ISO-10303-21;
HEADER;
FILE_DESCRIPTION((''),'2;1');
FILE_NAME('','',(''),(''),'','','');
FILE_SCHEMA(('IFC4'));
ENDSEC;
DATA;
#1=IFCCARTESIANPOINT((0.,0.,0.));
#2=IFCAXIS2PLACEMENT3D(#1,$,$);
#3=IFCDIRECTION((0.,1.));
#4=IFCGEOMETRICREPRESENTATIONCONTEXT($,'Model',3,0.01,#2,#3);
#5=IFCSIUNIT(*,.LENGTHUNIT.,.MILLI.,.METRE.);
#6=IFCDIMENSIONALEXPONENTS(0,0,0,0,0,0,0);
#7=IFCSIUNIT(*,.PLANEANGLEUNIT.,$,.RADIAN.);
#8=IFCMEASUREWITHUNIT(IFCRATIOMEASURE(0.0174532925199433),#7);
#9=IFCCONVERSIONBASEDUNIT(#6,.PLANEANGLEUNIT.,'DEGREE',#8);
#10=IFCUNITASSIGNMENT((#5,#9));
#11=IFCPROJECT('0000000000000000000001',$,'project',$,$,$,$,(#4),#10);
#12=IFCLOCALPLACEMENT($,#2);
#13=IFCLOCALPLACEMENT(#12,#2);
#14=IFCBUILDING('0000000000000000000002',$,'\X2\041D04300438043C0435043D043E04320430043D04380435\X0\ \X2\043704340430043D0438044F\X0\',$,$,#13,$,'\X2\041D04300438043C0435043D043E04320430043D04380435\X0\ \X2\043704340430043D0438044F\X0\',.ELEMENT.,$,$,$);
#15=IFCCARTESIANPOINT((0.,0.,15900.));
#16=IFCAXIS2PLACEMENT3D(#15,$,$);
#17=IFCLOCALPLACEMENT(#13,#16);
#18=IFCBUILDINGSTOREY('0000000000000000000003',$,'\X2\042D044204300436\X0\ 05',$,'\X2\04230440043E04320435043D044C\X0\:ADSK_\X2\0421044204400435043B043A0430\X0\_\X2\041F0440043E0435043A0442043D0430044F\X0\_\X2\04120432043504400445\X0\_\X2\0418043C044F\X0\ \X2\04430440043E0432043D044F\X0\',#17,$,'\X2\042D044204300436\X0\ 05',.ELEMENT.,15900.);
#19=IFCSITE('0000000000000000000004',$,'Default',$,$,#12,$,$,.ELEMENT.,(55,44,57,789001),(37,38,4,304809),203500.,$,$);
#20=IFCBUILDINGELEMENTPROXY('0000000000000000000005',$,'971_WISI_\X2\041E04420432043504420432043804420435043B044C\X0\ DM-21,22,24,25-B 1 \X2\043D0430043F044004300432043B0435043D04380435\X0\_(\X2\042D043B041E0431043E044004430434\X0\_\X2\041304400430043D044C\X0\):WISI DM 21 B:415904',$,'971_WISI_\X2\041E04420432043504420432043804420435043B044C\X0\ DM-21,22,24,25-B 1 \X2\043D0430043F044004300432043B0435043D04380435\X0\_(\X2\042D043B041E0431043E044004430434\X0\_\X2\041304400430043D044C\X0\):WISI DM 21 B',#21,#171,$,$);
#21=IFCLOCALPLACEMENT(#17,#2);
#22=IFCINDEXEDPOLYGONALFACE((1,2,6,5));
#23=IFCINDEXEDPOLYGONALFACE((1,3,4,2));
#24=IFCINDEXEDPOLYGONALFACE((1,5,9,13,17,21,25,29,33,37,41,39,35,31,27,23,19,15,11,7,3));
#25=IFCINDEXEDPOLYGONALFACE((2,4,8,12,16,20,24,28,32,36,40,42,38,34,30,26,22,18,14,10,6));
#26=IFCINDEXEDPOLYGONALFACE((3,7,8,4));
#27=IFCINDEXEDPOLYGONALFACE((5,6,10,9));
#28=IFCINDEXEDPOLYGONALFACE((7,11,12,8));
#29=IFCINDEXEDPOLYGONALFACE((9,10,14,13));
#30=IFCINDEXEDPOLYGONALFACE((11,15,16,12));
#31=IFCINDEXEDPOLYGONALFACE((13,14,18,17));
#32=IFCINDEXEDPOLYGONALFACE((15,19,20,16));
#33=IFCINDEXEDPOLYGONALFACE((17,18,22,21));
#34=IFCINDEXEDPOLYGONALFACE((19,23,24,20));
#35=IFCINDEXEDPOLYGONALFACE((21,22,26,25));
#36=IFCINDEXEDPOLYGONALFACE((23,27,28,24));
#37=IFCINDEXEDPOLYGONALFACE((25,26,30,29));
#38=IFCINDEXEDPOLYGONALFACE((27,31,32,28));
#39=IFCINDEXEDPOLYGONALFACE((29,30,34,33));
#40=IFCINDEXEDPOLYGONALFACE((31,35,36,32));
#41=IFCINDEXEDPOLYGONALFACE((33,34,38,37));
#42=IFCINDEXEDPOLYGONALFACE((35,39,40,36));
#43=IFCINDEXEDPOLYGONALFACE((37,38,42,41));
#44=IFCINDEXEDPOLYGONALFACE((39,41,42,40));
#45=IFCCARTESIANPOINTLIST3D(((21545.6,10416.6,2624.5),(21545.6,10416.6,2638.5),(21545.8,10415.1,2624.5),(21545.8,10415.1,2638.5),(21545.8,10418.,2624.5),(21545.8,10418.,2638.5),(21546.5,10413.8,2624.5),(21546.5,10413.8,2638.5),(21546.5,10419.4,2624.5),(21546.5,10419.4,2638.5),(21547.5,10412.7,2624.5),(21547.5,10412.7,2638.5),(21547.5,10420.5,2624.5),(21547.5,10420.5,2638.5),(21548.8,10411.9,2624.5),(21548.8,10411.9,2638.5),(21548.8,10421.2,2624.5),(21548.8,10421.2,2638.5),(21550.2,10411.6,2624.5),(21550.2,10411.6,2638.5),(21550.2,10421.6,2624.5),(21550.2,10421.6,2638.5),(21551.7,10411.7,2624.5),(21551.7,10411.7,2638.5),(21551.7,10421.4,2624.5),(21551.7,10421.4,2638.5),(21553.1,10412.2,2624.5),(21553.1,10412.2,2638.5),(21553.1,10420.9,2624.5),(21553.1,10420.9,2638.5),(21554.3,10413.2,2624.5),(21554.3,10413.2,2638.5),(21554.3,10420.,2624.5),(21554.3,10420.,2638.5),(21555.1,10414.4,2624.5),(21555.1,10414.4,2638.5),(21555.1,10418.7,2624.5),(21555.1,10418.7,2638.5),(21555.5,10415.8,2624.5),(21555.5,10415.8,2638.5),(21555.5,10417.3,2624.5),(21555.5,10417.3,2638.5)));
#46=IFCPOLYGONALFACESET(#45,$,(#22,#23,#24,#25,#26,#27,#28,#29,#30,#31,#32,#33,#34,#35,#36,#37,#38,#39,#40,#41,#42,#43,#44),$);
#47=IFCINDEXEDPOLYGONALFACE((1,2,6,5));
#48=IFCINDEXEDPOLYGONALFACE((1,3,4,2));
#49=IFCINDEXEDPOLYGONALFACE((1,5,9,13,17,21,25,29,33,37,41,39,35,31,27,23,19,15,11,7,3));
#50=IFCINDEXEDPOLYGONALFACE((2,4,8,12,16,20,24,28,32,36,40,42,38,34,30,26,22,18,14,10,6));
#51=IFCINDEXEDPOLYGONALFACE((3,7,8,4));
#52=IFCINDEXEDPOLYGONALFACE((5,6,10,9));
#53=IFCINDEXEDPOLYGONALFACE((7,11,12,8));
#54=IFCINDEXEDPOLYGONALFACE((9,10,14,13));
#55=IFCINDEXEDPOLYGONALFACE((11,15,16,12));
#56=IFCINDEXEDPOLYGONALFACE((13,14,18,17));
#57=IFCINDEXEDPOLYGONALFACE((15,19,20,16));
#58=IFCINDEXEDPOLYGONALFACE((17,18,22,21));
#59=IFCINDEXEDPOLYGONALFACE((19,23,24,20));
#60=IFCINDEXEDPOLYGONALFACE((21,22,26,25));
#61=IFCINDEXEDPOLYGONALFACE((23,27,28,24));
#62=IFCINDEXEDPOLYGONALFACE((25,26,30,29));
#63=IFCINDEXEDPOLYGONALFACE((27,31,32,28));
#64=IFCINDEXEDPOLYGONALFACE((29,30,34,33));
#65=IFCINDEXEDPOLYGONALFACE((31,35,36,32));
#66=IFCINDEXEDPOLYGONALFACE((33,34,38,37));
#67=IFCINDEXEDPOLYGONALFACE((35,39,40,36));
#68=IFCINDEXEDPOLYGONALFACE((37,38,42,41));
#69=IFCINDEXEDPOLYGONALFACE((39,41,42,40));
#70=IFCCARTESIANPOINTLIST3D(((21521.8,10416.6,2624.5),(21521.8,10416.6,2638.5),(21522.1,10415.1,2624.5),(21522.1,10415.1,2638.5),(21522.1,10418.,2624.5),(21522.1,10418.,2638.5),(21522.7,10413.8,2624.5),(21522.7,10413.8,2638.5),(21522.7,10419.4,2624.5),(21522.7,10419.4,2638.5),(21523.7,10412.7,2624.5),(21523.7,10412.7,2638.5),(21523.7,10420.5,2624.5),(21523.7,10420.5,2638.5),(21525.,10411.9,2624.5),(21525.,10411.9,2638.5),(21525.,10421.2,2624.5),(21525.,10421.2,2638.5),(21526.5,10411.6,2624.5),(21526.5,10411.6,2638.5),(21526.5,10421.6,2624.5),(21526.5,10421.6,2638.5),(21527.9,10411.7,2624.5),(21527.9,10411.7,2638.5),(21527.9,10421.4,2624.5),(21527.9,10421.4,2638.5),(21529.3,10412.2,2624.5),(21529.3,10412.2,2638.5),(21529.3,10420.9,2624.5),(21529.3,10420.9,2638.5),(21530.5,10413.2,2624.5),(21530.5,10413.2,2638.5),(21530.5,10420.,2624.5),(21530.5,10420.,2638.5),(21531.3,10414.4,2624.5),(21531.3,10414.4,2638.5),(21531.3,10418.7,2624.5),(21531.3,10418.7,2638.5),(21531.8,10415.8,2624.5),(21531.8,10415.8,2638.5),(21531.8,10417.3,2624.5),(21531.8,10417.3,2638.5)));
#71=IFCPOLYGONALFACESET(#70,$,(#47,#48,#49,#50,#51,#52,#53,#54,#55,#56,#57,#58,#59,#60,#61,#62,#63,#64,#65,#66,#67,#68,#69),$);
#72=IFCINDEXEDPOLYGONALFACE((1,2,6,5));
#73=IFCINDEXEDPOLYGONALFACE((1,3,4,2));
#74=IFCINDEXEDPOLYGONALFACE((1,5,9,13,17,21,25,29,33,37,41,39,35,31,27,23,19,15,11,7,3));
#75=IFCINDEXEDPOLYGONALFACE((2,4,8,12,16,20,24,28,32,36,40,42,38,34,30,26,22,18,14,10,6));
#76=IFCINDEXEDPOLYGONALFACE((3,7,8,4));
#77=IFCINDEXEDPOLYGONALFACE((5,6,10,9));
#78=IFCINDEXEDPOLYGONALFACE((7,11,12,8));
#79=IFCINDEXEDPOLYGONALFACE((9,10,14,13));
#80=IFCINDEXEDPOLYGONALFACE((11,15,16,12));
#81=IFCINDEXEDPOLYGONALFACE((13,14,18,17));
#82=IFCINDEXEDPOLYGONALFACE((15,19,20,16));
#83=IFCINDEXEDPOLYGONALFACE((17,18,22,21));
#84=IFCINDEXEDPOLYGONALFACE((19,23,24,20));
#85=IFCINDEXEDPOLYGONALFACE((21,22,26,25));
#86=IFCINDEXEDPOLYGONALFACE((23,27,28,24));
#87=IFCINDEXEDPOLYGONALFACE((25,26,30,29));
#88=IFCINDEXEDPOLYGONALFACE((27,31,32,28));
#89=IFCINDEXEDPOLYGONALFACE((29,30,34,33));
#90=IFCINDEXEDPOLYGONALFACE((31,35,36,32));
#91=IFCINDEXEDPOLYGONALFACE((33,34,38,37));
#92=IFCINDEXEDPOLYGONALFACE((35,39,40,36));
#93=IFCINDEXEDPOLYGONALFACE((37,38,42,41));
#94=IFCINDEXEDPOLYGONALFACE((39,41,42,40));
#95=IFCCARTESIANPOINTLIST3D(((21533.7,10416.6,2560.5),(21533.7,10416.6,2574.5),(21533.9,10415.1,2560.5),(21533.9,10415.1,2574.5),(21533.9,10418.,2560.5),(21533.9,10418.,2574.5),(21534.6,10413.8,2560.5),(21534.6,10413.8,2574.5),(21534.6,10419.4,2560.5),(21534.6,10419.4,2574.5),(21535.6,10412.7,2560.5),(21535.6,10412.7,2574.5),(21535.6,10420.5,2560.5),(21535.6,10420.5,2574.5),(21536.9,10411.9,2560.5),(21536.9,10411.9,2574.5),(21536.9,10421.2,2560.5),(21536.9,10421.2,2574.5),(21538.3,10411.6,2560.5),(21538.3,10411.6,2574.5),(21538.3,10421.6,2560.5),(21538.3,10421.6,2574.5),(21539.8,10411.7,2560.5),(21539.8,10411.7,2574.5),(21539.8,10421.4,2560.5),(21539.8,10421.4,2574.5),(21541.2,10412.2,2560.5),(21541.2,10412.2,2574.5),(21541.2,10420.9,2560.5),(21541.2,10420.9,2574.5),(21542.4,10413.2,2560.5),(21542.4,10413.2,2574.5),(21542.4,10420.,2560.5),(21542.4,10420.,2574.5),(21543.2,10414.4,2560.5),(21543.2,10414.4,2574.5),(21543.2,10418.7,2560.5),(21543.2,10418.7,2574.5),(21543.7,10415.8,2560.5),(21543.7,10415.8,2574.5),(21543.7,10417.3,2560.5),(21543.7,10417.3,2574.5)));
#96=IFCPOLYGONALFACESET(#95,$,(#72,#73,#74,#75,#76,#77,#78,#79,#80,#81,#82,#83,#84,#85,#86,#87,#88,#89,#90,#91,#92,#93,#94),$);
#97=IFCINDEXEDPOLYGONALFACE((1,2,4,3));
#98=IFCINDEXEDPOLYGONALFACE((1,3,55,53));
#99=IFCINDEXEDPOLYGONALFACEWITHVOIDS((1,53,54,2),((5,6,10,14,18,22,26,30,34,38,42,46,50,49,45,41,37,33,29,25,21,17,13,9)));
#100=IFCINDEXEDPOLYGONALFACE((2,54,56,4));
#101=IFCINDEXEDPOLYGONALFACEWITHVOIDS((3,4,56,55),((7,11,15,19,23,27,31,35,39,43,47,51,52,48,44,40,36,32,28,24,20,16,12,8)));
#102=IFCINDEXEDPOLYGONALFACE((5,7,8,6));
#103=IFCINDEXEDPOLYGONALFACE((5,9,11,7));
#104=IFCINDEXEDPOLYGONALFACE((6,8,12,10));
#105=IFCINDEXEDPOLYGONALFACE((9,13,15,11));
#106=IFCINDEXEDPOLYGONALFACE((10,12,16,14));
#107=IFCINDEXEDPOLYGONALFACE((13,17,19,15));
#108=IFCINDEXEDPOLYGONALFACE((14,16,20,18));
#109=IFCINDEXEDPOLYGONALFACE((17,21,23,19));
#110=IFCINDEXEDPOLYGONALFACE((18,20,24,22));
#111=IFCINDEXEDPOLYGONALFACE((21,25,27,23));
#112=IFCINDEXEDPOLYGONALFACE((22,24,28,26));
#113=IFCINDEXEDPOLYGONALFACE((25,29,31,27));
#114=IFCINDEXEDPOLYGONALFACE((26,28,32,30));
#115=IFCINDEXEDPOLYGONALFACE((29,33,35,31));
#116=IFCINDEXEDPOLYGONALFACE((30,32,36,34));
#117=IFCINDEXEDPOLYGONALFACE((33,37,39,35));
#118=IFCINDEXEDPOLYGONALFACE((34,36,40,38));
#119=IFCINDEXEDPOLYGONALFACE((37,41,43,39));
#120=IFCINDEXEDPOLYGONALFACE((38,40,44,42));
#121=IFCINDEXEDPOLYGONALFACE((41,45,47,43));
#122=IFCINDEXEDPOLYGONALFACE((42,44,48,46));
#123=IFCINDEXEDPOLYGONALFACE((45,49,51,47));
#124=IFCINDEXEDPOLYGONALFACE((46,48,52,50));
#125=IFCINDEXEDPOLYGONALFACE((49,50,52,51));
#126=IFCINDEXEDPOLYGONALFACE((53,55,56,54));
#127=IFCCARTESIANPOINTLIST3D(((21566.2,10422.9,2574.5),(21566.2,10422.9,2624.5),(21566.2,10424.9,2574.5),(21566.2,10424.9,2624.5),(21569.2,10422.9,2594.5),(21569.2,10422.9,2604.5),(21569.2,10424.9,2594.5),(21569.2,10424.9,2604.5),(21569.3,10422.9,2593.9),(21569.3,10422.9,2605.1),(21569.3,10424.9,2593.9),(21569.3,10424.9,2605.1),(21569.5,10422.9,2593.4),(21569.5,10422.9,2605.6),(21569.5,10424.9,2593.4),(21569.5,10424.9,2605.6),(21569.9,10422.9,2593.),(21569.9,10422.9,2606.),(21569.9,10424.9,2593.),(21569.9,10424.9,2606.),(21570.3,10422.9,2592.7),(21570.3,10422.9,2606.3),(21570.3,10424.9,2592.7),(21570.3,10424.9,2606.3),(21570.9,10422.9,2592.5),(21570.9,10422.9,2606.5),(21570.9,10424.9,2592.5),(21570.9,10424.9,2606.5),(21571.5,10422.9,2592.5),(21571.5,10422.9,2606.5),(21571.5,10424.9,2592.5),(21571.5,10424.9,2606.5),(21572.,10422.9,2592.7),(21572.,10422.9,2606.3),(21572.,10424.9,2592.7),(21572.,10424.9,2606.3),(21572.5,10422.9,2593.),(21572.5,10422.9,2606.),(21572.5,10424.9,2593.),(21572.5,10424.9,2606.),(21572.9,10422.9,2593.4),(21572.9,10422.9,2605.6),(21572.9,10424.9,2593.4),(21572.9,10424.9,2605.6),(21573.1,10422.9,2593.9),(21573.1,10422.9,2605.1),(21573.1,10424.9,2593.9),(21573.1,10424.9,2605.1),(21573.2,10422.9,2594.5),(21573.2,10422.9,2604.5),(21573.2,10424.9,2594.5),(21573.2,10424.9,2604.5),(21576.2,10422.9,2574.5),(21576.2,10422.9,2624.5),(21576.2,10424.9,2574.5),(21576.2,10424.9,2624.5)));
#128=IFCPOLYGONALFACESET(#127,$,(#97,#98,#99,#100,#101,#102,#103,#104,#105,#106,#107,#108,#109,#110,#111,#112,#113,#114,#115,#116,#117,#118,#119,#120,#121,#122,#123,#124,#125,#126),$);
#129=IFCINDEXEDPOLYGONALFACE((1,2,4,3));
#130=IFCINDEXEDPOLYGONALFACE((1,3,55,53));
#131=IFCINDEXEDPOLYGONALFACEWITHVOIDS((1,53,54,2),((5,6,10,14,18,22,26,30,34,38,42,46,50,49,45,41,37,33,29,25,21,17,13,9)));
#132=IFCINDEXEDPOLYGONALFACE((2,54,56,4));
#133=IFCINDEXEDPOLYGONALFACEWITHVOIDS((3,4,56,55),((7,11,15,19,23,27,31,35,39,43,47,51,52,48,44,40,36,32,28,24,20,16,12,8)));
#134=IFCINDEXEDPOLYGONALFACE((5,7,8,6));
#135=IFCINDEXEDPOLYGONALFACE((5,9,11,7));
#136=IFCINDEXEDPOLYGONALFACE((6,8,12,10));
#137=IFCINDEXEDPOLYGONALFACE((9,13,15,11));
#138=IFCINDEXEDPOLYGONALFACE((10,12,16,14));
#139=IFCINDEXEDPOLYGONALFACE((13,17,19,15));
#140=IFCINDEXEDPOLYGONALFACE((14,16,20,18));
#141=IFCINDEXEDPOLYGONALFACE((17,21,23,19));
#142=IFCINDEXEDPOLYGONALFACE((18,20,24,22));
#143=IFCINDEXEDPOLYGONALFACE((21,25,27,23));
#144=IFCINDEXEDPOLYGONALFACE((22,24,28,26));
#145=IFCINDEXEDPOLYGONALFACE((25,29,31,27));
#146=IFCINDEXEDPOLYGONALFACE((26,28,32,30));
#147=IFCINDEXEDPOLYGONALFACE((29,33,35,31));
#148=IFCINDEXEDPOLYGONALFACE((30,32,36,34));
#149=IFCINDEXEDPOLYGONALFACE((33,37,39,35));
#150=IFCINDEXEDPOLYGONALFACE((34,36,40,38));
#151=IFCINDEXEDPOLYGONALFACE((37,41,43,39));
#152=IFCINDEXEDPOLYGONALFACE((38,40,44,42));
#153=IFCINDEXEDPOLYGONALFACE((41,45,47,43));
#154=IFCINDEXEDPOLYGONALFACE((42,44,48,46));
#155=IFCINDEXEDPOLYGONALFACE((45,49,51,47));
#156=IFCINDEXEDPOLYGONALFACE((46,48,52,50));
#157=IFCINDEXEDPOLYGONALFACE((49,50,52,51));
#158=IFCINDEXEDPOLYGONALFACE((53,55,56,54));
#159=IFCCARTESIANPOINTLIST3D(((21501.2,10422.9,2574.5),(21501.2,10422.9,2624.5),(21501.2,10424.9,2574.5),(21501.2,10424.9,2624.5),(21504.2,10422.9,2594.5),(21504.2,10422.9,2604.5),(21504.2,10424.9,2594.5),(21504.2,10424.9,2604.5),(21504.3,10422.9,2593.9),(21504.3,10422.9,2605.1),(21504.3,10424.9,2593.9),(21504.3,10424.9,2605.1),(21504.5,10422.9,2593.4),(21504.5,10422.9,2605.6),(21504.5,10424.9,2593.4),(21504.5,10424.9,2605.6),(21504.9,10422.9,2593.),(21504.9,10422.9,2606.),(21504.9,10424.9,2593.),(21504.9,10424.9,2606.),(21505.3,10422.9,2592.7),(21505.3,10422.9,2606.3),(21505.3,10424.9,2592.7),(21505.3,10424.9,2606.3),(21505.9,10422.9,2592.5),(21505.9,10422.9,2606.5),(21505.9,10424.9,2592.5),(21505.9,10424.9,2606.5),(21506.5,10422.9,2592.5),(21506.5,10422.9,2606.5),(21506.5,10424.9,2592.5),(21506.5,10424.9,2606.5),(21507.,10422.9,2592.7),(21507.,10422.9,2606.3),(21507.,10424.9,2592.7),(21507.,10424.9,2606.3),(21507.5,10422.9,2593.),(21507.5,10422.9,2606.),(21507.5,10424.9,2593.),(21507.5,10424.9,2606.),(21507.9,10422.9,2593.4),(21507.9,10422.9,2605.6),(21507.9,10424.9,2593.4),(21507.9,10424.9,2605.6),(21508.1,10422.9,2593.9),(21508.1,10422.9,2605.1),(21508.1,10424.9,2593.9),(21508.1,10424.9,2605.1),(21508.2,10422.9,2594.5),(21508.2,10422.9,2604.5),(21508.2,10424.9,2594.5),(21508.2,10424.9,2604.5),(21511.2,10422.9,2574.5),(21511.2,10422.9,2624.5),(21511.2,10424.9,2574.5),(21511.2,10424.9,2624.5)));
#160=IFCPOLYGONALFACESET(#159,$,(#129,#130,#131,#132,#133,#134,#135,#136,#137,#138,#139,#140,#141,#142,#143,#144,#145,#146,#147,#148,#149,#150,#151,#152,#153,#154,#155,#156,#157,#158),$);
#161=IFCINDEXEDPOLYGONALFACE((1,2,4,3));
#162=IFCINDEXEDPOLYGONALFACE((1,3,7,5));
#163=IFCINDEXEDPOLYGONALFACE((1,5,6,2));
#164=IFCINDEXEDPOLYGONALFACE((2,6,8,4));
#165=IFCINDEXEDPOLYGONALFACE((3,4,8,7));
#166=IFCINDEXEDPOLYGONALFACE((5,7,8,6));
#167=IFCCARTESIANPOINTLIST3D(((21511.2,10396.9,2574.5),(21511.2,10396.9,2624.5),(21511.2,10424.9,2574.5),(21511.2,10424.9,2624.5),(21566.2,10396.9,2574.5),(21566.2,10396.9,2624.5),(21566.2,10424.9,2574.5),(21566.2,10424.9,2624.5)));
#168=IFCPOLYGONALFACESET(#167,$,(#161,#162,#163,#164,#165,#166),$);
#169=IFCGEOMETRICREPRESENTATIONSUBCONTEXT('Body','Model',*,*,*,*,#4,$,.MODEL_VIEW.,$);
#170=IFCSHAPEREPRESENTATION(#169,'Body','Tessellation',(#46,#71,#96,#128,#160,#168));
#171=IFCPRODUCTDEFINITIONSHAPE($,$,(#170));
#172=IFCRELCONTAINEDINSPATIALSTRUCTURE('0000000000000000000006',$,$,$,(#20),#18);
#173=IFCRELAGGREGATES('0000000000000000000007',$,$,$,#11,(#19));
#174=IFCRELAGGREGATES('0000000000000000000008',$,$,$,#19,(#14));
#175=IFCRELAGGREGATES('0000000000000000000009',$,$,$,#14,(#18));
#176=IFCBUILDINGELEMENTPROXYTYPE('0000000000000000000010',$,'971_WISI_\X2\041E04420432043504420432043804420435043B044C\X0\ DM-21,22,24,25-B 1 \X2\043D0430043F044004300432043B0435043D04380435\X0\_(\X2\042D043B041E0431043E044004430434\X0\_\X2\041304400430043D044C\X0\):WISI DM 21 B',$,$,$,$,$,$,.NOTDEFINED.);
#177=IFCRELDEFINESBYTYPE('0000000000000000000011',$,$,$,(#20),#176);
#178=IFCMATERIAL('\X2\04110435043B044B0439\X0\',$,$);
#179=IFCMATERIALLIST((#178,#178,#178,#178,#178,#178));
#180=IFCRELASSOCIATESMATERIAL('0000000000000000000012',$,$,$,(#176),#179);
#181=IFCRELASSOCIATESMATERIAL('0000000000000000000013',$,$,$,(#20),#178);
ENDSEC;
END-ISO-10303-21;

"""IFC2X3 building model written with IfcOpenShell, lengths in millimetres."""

from ifc_helpers import new_model, entity, si_unit, converted_unit, direction, frame, origin, origin_2d_with_axis, place, context, subcontext, project, spatial, rectangle, circle, extrude, source, transform, mapped, material, material_list, type_object, type_shapes, element, save


model = new_model("IFC2X3")

# Units and contexts
model_context = context("Model", 3, precision=0.01, world=origin(), true_north=direction((0.0, 1.0)))
body_context = subcontext(model_context, "Body", "Model", "MODEL_VIEW")
ifc_project = project(units=[si_unit("LENGTHUNIT", "METRE", prefix="MILLI"), converted_unit("PLANEANGLEUNIT", "DEGREE", entity("IfcRatioMeasure", 0.0174532925199433), si_unit("PLANEANGLEUNIT", "RADIAN"), dimensions=[0, 0, 0, 0, 0, 0, 0])], contexts=[model_context])

# Site, building, storey
site_placement = place(None, origin())
site = spatial("IfcSite", under=ifc_project, at=site_placement, Name="Default", CompositionType="ELEMENT", RefLatitude=(55, 44, 57, 789001), RefLongitude=(37, 38, 4, 304809), RefElevation=203500.0)
building_placement = place(site_placement, origin())
building = spatial("IfcBuilding", under=site, at=building_placement, Name="Наименование здания", LongName="Наименование здания", CompositionType="ELEMENT")
storey_placement = place(building_placement, frame((0.0, 0.0, 15900.0)))
storey = spatial("IfcBuildingStorey", under=building, at=storey_placement, Name="Этаж 05", ObjectType="Уровень:ADSK_Стрелка_Проектная_Вверх_Имя уровня", LongName="Этаж 05", CompositionType="ELEMENT", Elevation=15900.0)

# Building element proxy
ifc_material = material(Name="Белый")
ifc_material_list = material_list([ifc_material, ifc_material, ifc_material, ifc_material, ifc_material, ifc_material])
building_element_proxy_type = type_object("IfcBuildingElementProxyType", Name="971_WISI_Ответвитель DM-21,22,24,25-B 1 направление_(ЭлОборуд_Грань):WISI DM 21 B", PredefinedType="NOTDEFINED", material=ifc_material_list)
cartesian_point = entity("IfcCartesianPoint", [-5.0, -25.0])
shared_polyline = entity("IfcPolyline", [cartesian_point, entity("IfcCartesianPoint", [5.0, -25.0]), entity("IfcCartesianPoint", [5.0, 25.0]), entity("IfcCartesianPoint", [-5.0, 25.0]), cartesian_point])
ifc_direction_1 = entity("IfcDirection", [-1.0, 0.0])
ifc_direction_2 = entity("IfcDirection", [0.0, 0.0, 1.0])
ifc_direction_3 = entity("IfcDirection", [-1.0, 0.0])
ifc_direction_4 = entity("IfcDirection", [0.0, 0.0, 1.0])
shared_shape = source(origin(), body_context, "Body", "SweptSolid", [
    extrude(circle(Radius=5.0, at=origin_2d_with_axis()), frame((11.9, 25.0, 8.4), z_axis=(0.0, 1.0, 0.0), x_axis=(-1.0, 0.0, 0.0)), (0.0, 0.0, 1.0), 14.0),
    extrude(circle(Radius=5.0, at=origin_2d_with_axis()), frame((-11.8, 25.0, 8.4), z_axis=(0.0, 1.0, 0.0), x_axis=(-1.0, 0.0, 0.0)), (0.0, 0.0, 1.0), 14.0),
    extrude(circle(Radius=5.0, at=origin_2d_with_axis()), frame((0.0, -39.0, 8.4), z_axis=(0.0, 1.0, 0.0), x_axis=(-1.0, 0.0, 0.0)), (0.0, 0.0, 1.0), 14.0),
    entity("IfcExtrudedAreaSolid", entity("IfcArbitraryProfileDefWithVoids", "AREA", None, shared_polyline, [entity("IfcCompositeCurve", [entity("IfcCompositeCurveSegment", "CONTINUOUS", True, entity("IfcPolyline", [entity("IfcCartesianPoint", [2.0, 5.0]), entity("IfcCartesianPoint", [2.0, -5.0])])), entity("IfcCompositeCurveSegment", "CONTINUOUS", False, entity("IfcTrimmedCurve", entity("IfcCircle", entity("IfcAxis2Placement2D", entity("IfcCartesianPoint", [0.0, -5.0]), ifc_direction_1), 2.0), [entity("IfcParameterValue", 0.0)], [entity("IfcParameterValue", 180.0)], True, "PARAMETER")), entity("IfcCompositeCurveSegment", "CONTINUOUS", True, entity("IfcPolyline", [entity("IfcCartesianPoint", [-2.0, -5.0]), entity("IfcCartesianPoint", [-2.0, 5.0])])), entity("IfcCompositeCurveSegment", "CONTINUOUS", False, entity("IfcTrimmedCurve", entity("IfcCircle", entity("IfcAxis2Placement2D", entity("IfcCartesianPoint", [0.0, 5.0]), ifc_direction_1), 2.0), [entity("IfcParameterValue", 180.0)], [entity("IfcParameterValue", 0.0)], True, "PARAMETER"))], False)]), entity("IfcAxis2Placement3D", entity("IfcCartesianPoint", [32.5, 0.0, 0.0]), ifc_direction_2, entity("IfcDirection", [-1.0, 0.0, 0.0])), ifc_direction_2, 2.0),
    entity("IfcExtrudedAreaSolid", entity("IfcArbitraryProfileDefWithVoids", "AREA", None, shared_polyline, [entity("IfcCompositeCurve", [entity("IfcCompositeCurveSegment", "CONTINUOUS", True, entity("IfcPolyline", [entity("IfcCartesianPoint", [-2.0, -5.0]), entity("IfcCartesianPoint", [-2.0, 5.0])])), entity("IfcCompositeCurveSegment", "CONTINUOUS", False, entity("IfcTrimmedCurve", entity("IfcCircle", entity("IfcAxis2Placement2D", entity("IfcCartesianPoint", [0.0, 5.0]), ifc_direction_3), 2.0), [entity("IfcParameterValue", 180.0)], [entity("IfcParameterValue", 0.0)], True, "PARAMETER")), entity("IfcCompositeCurveSegment", "CONTINUOUS", True, entity("IfcPolyline", [entity("IfcCartesianPoint", [2.0, 5.0]), entity("IfcCartesianPoint", [2.0, -5.0])])), entity("IfcCompositeCurveSegment", "CONTINUOUS", False, entity("IfcTrimmedCurve", entity("IfcCircle", entity("IfcAxis2Placement2D", entity("IfcCartesianPoint", [0.0, -5.0]), ifc_direction_3), 2.0), [entity("IfcParameterValue", 0.0)], [entity("IfcParameterValue", 180.0)], True, "PARAMETER"))], False)]), entity("IfcAxis2Placement3D", entity("IfcCartesianPoint", [-32.5, 0.0, 0.0]), ifc_direction_4, entity("IfcDirection", [-1.0, 0.0, 0.0])), ifc_direction_4, 2.0),
    extrude(rectangle(XDim=55.0, YDim=50.0, at=origin_2d_with_axis()), frame((0.0, 0.0, 0.0), z_axis=(0.0, 0.0, 1.0), x_axis=(-1.0, 0.0, 0.0)), (0.0, 0.0, 1.0), 28.0),
])
type_shapes(building_element_proxy_type, [shared_shape])
for number, where, z_axis, x_axis, name in (
    (1, (21538.7, 10424.9, 2599.5), (0.0, -1.0, 0.0), (1.0, 0.0, 0.0), "971_WISI_Ответвитель DM-21,22,24,25-B 1 направление_(ЭлОборуд_Грань):WISI DM 21 B:415904"),
):
    element("IfcBuildingElementProxy", number, at=place(storey_placement, frame(where, z_axis=z_axis, x_axis=x_axis)), inside=storey, type_object=building_element_proxy_type, material=ifc_material, Name=name, ObjectType="971_WISI_Ответвитель DM-21,22,24,25-B 1 направление_(ЭлОборуд_Грань):WISI DM 21 B", context=body_context, shape_type="MappedRepresentation", body=[
        mapped(shared_shape, transform((0.0, 0.0, 0.0), scale=1.0)),
    ])

save(model, "model.ifc")
